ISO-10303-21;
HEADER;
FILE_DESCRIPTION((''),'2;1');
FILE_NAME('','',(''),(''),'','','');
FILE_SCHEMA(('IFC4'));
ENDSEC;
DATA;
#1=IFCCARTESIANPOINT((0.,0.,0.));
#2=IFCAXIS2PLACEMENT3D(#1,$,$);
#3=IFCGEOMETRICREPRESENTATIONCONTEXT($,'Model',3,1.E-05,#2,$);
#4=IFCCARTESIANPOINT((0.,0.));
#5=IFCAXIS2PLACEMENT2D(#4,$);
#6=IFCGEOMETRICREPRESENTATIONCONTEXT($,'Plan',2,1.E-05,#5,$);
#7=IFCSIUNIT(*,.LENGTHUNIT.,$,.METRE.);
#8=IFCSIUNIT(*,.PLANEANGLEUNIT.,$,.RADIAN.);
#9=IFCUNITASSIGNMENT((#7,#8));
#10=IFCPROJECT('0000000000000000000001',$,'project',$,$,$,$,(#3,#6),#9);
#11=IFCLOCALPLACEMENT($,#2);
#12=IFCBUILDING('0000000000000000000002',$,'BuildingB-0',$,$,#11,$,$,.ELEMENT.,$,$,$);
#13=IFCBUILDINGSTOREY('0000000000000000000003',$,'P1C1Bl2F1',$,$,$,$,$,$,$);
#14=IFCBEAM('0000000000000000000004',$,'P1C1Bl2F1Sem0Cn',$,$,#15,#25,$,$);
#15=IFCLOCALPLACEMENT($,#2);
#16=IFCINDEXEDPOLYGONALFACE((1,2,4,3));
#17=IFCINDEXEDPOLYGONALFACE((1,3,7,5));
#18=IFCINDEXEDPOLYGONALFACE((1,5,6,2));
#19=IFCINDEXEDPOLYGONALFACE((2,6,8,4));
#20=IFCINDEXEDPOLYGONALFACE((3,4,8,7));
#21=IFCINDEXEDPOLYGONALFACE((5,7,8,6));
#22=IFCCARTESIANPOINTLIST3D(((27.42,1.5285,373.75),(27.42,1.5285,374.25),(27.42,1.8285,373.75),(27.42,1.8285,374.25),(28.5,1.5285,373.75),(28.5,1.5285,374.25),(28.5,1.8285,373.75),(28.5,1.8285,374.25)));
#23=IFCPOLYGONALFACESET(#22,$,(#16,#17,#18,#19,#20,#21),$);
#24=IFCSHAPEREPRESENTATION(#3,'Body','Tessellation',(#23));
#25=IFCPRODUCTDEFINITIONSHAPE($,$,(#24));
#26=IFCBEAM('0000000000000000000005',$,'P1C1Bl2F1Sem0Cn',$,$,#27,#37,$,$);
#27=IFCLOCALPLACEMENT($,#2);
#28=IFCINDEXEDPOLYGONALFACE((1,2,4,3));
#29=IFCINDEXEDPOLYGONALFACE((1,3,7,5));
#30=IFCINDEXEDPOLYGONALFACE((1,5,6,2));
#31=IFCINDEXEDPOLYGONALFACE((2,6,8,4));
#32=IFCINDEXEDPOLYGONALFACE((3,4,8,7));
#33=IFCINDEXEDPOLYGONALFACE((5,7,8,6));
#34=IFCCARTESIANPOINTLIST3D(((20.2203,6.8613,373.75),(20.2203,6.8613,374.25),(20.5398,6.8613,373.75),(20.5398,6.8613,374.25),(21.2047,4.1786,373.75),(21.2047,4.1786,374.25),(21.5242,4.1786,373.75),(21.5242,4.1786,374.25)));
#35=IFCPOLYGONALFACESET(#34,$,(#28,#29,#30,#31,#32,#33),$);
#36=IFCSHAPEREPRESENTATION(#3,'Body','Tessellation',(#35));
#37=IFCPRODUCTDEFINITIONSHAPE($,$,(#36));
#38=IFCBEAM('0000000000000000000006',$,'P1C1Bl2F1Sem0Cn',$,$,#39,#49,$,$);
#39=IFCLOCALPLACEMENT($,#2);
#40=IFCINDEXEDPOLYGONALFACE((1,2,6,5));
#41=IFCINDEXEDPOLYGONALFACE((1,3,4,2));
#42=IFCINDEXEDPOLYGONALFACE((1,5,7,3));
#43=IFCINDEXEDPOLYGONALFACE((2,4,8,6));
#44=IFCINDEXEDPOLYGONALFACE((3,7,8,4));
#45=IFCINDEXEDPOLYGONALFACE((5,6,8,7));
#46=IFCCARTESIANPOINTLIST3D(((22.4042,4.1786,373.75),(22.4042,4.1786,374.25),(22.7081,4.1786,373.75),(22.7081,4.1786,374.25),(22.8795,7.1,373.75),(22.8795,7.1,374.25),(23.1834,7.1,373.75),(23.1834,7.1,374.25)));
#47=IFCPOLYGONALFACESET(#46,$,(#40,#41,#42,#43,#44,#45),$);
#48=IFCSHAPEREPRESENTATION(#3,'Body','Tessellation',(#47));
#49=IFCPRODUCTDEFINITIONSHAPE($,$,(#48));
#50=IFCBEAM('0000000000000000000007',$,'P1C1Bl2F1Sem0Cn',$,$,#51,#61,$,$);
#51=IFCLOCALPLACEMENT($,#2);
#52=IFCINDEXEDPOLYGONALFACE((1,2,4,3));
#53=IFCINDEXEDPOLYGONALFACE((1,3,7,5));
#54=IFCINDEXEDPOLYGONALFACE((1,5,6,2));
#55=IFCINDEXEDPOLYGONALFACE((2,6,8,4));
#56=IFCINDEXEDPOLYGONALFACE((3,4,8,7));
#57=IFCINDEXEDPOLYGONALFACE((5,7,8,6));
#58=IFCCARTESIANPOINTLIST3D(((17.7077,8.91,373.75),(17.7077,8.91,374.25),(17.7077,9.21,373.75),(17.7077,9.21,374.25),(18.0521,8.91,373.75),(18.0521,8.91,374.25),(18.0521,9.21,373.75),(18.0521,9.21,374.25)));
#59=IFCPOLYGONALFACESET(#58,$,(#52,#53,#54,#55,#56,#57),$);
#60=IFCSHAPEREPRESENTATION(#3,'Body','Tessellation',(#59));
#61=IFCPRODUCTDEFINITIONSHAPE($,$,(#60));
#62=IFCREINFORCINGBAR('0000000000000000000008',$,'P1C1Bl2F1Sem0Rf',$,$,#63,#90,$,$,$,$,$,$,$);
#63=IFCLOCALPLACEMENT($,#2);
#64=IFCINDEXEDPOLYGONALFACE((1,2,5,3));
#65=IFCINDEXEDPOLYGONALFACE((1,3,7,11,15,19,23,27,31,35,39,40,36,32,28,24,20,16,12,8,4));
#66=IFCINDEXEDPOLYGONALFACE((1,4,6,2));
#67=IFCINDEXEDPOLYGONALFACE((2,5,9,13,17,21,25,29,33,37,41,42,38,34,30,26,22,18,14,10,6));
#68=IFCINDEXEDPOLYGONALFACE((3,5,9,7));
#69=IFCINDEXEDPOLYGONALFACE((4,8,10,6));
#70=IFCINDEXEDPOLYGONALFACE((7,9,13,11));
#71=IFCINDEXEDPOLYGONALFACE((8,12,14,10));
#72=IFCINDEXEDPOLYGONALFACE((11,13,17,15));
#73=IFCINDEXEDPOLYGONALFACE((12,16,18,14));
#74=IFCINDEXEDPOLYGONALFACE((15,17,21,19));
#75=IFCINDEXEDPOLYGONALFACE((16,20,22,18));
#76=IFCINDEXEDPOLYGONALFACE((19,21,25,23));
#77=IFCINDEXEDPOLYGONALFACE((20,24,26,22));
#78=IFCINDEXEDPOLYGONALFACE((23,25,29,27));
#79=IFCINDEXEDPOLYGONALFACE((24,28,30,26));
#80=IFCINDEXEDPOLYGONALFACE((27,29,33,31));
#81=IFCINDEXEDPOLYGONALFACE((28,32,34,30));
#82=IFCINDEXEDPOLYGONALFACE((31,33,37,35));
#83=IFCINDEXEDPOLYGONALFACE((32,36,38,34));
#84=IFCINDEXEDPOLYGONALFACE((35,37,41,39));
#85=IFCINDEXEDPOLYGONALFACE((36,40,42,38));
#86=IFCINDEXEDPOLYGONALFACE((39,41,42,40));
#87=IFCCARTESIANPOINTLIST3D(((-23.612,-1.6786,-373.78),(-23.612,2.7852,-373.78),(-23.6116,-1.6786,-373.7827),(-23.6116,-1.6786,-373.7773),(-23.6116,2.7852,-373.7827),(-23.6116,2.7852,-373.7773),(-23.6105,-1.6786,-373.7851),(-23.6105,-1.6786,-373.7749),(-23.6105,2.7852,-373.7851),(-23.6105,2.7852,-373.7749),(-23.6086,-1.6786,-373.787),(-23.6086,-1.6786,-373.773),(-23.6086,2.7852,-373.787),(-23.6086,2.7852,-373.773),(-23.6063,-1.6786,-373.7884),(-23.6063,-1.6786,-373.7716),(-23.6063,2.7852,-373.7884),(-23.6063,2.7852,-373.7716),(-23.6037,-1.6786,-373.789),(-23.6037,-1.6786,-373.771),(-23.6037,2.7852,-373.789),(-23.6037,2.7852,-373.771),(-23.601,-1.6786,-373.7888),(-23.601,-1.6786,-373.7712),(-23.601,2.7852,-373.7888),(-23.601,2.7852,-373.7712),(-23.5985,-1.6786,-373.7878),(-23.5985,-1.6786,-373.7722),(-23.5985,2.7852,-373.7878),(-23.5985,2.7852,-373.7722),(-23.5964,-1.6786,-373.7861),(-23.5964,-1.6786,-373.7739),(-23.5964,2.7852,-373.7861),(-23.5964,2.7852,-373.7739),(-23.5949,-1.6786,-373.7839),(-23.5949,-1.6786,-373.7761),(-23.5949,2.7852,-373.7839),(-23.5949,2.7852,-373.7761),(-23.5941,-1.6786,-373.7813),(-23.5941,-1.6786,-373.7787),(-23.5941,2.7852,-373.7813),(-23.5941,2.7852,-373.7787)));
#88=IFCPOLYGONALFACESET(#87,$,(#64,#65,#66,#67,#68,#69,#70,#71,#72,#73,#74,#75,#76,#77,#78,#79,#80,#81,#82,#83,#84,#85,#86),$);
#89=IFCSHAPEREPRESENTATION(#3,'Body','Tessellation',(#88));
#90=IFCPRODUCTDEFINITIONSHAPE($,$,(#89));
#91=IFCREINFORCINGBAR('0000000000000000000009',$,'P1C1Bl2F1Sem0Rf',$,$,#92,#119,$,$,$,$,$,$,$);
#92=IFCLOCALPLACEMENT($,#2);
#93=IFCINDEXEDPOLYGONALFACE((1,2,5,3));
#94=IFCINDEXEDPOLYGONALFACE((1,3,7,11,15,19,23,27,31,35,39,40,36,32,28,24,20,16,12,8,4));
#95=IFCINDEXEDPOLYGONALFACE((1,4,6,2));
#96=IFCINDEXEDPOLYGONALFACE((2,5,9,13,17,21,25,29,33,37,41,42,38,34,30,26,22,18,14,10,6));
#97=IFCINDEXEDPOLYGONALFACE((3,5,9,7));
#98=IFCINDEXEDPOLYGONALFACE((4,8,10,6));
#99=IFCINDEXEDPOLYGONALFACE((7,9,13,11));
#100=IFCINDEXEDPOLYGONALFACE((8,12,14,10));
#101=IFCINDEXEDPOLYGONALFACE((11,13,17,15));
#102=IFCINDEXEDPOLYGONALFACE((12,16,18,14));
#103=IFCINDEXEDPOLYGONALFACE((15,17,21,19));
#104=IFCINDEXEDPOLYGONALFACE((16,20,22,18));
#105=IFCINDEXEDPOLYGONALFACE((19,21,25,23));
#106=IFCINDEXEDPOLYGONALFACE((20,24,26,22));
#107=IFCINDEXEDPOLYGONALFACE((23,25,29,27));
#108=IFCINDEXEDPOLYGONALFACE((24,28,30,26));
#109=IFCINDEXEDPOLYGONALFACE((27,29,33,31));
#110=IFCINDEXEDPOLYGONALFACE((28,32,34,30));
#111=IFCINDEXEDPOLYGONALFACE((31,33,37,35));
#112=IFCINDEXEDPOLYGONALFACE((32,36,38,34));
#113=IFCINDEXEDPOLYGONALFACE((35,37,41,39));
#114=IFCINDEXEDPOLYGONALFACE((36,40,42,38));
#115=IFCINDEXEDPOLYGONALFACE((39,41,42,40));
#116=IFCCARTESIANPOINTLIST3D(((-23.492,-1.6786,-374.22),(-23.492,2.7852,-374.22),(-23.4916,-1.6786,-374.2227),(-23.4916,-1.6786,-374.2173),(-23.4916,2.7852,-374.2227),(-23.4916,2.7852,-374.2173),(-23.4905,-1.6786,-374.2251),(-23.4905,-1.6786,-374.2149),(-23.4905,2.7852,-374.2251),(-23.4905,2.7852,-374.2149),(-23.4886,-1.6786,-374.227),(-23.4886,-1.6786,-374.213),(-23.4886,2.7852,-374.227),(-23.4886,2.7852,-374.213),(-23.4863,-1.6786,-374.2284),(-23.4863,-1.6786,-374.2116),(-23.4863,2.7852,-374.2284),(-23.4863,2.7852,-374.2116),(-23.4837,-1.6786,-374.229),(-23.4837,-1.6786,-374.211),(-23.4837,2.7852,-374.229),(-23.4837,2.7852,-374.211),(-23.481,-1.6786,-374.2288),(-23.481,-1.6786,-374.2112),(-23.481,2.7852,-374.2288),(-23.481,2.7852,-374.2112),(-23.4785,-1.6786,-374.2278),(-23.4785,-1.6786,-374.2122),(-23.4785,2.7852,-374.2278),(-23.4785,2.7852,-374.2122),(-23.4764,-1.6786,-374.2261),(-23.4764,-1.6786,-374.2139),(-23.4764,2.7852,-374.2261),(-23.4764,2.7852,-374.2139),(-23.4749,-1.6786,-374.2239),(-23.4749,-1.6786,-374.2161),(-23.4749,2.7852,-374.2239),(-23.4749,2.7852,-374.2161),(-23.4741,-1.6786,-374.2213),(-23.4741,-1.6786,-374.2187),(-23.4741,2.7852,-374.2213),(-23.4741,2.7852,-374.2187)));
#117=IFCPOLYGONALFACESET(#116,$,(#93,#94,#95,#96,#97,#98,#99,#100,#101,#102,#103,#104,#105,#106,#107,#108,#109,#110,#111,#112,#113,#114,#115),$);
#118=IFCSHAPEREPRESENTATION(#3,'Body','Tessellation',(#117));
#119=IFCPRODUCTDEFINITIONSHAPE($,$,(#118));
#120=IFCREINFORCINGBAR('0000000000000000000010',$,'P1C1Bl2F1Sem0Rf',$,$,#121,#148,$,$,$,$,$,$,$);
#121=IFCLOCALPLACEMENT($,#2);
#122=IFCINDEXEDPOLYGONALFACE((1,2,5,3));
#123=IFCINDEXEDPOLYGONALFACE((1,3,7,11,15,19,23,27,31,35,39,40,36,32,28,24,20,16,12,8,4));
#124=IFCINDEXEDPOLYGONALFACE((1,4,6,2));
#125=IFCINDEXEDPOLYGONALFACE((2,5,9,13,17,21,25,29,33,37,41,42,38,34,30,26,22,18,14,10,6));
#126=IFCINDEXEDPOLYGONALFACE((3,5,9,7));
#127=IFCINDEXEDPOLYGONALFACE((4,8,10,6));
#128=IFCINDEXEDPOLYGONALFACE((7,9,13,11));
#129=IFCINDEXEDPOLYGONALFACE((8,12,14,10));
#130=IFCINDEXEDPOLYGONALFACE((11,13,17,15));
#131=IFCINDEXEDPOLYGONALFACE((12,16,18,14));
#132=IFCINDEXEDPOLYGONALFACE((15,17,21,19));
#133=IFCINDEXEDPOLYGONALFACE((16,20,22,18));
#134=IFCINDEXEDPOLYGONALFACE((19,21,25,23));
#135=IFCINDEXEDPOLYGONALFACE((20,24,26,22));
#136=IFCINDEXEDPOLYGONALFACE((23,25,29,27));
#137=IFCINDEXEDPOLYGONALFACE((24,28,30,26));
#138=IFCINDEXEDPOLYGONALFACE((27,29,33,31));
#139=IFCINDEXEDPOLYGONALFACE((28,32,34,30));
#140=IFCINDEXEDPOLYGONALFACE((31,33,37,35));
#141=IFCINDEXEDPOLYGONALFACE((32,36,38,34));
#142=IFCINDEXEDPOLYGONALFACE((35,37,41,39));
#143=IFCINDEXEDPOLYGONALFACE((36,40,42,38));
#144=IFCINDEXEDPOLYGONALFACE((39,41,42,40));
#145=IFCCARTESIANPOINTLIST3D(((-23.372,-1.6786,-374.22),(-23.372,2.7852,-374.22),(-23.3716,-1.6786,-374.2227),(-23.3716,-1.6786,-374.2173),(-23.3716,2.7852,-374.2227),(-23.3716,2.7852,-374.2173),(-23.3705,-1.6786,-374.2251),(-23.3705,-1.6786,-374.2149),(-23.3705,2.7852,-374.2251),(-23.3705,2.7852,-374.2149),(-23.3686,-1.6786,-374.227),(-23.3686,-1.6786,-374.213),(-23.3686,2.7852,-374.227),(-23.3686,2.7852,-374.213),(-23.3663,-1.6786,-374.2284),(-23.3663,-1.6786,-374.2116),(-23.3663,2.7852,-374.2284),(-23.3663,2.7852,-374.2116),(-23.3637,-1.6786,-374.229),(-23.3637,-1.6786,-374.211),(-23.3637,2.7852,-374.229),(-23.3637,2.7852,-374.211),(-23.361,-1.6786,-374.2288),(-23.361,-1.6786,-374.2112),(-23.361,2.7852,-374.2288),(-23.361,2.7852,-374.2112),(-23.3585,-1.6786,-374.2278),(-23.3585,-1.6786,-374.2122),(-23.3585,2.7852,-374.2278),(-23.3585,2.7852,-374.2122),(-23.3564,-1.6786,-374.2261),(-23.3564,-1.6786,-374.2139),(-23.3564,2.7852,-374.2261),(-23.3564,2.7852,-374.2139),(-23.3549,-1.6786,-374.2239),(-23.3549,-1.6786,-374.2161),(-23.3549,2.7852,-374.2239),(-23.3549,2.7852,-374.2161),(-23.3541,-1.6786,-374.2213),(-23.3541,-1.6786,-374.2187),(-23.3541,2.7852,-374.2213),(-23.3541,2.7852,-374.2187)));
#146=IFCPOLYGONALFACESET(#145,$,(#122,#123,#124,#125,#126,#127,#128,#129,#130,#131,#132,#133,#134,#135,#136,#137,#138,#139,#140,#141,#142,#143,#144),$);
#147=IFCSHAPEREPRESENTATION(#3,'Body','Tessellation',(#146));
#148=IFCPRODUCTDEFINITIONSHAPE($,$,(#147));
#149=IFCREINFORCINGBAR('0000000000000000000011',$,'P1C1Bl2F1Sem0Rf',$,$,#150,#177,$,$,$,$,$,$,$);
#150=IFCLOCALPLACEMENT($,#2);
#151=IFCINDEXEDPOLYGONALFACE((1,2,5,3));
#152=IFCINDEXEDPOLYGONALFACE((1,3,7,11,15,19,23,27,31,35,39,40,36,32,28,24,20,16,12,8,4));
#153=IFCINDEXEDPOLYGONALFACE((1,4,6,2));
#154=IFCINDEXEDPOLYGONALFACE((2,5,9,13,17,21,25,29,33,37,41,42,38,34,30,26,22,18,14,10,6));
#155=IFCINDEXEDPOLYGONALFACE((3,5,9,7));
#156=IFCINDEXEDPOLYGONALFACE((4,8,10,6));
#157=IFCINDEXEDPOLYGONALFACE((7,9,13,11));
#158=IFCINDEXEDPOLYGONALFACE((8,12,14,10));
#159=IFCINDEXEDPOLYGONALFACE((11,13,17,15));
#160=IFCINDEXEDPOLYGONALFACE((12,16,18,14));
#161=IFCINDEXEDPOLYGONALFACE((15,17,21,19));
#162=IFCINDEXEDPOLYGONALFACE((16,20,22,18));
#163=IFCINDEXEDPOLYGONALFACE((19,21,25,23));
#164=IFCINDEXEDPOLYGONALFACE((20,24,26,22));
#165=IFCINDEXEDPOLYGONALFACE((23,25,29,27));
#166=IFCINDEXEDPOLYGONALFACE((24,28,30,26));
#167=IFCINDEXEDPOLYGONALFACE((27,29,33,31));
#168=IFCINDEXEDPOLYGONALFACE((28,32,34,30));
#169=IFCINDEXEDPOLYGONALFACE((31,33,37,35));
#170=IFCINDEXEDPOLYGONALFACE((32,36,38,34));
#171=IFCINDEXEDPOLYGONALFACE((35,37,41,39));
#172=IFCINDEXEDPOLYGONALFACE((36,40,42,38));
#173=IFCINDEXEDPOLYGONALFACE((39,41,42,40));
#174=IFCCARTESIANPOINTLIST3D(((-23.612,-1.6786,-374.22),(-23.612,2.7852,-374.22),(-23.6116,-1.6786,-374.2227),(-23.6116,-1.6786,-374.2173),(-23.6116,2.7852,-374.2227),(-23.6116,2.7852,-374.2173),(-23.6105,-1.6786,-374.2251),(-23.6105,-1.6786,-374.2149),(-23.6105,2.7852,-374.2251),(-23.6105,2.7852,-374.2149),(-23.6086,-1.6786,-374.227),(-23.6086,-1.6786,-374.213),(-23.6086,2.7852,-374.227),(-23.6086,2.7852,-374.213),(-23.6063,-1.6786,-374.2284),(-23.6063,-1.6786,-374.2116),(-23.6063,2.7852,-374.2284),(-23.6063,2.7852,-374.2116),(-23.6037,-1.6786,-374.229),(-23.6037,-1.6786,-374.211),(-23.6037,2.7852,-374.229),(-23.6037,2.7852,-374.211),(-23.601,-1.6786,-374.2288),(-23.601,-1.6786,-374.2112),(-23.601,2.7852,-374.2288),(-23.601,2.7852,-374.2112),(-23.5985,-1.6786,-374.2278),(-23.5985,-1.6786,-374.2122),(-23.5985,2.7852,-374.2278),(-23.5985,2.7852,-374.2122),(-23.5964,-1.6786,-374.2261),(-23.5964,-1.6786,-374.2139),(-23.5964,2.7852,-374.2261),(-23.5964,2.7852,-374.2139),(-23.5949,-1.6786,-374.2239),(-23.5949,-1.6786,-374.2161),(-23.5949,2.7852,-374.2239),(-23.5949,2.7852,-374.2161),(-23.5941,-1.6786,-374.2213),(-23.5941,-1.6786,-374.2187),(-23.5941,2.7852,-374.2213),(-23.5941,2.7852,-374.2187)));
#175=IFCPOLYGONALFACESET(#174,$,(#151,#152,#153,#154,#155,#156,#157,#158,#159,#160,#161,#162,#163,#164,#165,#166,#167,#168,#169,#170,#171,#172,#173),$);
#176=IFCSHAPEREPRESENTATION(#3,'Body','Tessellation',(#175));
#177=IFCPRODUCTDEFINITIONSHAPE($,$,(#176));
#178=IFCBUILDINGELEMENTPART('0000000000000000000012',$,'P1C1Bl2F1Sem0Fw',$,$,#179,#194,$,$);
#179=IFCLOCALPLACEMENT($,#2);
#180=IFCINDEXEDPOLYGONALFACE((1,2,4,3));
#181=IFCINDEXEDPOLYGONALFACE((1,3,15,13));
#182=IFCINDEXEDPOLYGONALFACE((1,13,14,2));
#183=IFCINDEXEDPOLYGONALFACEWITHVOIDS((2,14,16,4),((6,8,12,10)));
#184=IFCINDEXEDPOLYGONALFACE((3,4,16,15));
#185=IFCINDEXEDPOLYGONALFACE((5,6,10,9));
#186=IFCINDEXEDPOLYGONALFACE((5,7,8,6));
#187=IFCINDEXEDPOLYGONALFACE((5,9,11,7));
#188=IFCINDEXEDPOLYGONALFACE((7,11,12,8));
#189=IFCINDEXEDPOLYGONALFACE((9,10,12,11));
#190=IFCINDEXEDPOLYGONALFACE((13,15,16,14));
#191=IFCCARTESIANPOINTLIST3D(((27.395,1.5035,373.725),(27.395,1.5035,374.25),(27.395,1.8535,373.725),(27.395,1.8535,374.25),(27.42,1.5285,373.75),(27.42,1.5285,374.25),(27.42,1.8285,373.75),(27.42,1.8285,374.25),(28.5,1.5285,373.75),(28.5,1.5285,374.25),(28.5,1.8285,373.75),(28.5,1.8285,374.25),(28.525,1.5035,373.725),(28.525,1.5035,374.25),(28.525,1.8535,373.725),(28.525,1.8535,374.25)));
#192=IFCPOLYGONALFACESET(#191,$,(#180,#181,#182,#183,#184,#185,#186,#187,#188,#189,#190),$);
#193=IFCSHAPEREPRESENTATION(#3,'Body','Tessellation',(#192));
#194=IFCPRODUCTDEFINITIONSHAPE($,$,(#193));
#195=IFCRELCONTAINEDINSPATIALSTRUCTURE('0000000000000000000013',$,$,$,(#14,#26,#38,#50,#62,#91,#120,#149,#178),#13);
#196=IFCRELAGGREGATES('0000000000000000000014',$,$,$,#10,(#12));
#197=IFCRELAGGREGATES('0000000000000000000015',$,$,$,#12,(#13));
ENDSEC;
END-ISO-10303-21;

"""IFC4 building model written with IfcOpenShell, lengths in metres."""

from ifc_helpers import new_model, entity, si_unit, origin, origin_2d, place, context, project, spatial, polyline, outline, extrude, element, save


model = new_model("IFC4")

# Units and contexts
model_context = context("Model", 3, precision=1e-05, world=origin())
plan_context = context("Plan", 2, precision=1e-05, world=origin_2d())
ifc_project = project(units=[si_unit("LENGTHUNIT", "METRE"), si_unit("PLANEANGLEUNIT", "RADIAN")], contexts=[model_context, plan_context])

# Building, storey
building_placement = place(None, origin())
building = spatial("IfcBuilding", under=ifc_project, at=building_placement, Name="BuildingB-0", CompositionType="ELEMENT")
storey = spatial("IfcBuildingStorey", under=building, Name="P1C1Bl2F1")

# Beams
element("IfcBeam", 1, inside=storey, Name="P1C1Bl2F1Sem0Cn", context=model_context, shape_type="SweptSolid", body=[
    extrude(outline(polyline([(27.42, 1.5285, 373.75), (27.42, 1.8285, 373.75), (28.5, 1.8285, 373.75), (28.5, 1.5285, 373.75), (27.42, 1.5285, 373.75)])), None, (0.0, 0.0, 1.0), 0.5),
])
element("IfcBeam", 2, inside=storey, Name="P1C1Bl2F1Sem0Cn", context=model_context, shape_type="SweptSolid", body=[
    extrude(outline(polyline([(21.2047, 4.1786, 373.75), (21.5242, 4.1786, 373.75), (20.5398, 6.8613, 373.75), (20.2203, 6.8613, 373.75), (21.2047, 4.1786, 373.75)])), None, (0.0, 0.0, 1.0), 0.5),
])
element("IfcBeam", 3, inside=storey, Name="P1C1Bl2F1Sem0Cn", context=model_context, shape_type="SweptSolid", body=[
    extrude(outline(polyline([(22.4042, 4.1786, 373.75), (22.7081, 4.1786, 373.75), (23.1834, 7.1, 373.75), (22.8795, 7.1, 373.75), (22.4042, 4.1786, 373.75)])), None, (0.0, 0.0, 1.0), 0.5),
])
element("IfcBeam", 4, inside=storey, Name="P1C1Bl2F1Sem0Cn", context=model_context, shape_type="SweptSolid", body=[
    extrude(outline(polyline([(17.7077, 8.91, 373.75), (17.7077, 9.21, 373.75), (18.0521, 9.21, 373.75), (18.0521, 8.91, 373.75), (17.7077, 8.91, 373.75)])), None, (0.0, 0.0, 1.0), 0.5),
])

# Reinforcing bars
element("IfcReinforcingBar", 5, inside=storey, Name="P1C1Bl2F1Sem0Rf", context=model_context, shape_type="SweptSolid", body=[
    entity("IfcSurfaceCurveSweptAreaSolid", entity("IfcCircleProfileDef", "AREA", None, None, 0.009), None, entity("IfcPolyline", [entity("IfcCartesianPoint", [23.603, 1.6786, 373.78]), entity("IfcCartesianPoint", [23.603, -2.7852, 373.78])]), None, None, entity("IfcPlane", entity("IfcAxis2Placement3D", entity("IfcCartesianPoint", [23.603, 1.6786, 373.78]), entity("IfcDirection", [0.0, 0.0, 1.0]), entity("IfcDirection", [1.0, 0.0, 0.0])))),
])
element("IfcReinforcingBar", 6, inside=storey, Name="P1C1Bl2F1Sem0Rf", context=model_context, shape_type="SweptSolid", body=[
    entity("IfcSurfaceCurveSweptAreaSolid", entity("IfcCircleProfileDef", "AREA", None, None, 0.009), None, entity("IfcPolyline", [entity("IfcCartesianPoint", [23.483, 1.6786, 374.22]), entity("IfcCartesianPoint", [23.483, -2.7852, 374.22])]), None, None, entity("IfcPlane", entity("IfcAxis2Placement3D", entity("IfcCartesianPoint", [23.483, 1.6786, 374.22]), entity("IfcDirection", [0.0, 0.0, 1.0]), entity("IfcDirection", [1.0, 0.0, 0.0])))),
])
element("IfcReinforcingBar", 7, inside=storey, Name="P1C1Bl2F1Sem0Rf", context=model_context, shape_type="SweptSolid", body=[
    entity("IfcSurfaceCurveSweptAreaSolid", entity("IfcCircleProfileDef", "AREA", None, None, 0.009), None, entity("IfcPolyline", [entity("IfcCartesianPoint", [23.363, 1.6786, 374.22]), entity("IfcCartesianPoint", [23.363, -2.7852, 374.22])]), None, None, entity("IfcPlane", entity("IfcAxis2Placement3D", entity("IfcCartesianPoint", [23.363, 1.6786, 374.22]), entity("IfcDirection", [0.0, 0.0, 1.0]), entity("IfcDirection", [1.0, 0.0, 0.0])))),
])
element("IfcReinforcingBar", 8, inside=storey, Name="P1C1Bl2F1Sem0Rf", context=model_context, shape_type="SweptSolid", body=[
    entity("IfcSurfaceCurveSweptAreaSolid", entity("IfcCircleProfileDef", "AREA", None, None, 0.009), None, entity("IfcPolyline", [entity("IfcCartesianPoint", [23.603, 1.6786, 374.22]), entity("IfcCartesianPoint", [23.603, -2.7852, 374.22])]), None, None, entity("IfcPlane", entity("IfcAxis2Placement3D", entity("IfcCartesianPoint", [23.603, 1.6786, 374.22]), entity("IfcDirection", [0.0, 0.0, 1.0]), entity("IfcDirection", [1.0, 0.0, 0.0])))),
])

# Building element part, opening
building_element_part_1 = element("IfcBuildingElementPart", 9, inside=storey, Name="P1C1Bl2F1Sem0Fw", context=model_context, shape_type="SweptSolid", body=[
    extrude(outline(polyline([(27.395, 1.5035, 373.725), (27.395, 1.8535, 373.725), (28.525, 1.8535, 373.725), (28.525, 1.5035, 373.725), (27.395, 1.5035, 373.725)])), None, (0.0, 0.0, 1.0), 0.525),
])
element("IfcOpeningElement", 10, inside=storey, cuts=building_element_part_1, context=model_context, shape_type="SweptSolid", body=[
    extrude(outline(polyline([(27.42, 1.5285, 373.75), (27.42, 1.8285, 373.75), (28.5, 1.8285, 373.75), (28.5, 1.5285, 373.75), (27.42, 1.5285, 373.75)])), None, (0.0, 0.0, 1.0), 0.5),
])

save(model, "model.ifc")
